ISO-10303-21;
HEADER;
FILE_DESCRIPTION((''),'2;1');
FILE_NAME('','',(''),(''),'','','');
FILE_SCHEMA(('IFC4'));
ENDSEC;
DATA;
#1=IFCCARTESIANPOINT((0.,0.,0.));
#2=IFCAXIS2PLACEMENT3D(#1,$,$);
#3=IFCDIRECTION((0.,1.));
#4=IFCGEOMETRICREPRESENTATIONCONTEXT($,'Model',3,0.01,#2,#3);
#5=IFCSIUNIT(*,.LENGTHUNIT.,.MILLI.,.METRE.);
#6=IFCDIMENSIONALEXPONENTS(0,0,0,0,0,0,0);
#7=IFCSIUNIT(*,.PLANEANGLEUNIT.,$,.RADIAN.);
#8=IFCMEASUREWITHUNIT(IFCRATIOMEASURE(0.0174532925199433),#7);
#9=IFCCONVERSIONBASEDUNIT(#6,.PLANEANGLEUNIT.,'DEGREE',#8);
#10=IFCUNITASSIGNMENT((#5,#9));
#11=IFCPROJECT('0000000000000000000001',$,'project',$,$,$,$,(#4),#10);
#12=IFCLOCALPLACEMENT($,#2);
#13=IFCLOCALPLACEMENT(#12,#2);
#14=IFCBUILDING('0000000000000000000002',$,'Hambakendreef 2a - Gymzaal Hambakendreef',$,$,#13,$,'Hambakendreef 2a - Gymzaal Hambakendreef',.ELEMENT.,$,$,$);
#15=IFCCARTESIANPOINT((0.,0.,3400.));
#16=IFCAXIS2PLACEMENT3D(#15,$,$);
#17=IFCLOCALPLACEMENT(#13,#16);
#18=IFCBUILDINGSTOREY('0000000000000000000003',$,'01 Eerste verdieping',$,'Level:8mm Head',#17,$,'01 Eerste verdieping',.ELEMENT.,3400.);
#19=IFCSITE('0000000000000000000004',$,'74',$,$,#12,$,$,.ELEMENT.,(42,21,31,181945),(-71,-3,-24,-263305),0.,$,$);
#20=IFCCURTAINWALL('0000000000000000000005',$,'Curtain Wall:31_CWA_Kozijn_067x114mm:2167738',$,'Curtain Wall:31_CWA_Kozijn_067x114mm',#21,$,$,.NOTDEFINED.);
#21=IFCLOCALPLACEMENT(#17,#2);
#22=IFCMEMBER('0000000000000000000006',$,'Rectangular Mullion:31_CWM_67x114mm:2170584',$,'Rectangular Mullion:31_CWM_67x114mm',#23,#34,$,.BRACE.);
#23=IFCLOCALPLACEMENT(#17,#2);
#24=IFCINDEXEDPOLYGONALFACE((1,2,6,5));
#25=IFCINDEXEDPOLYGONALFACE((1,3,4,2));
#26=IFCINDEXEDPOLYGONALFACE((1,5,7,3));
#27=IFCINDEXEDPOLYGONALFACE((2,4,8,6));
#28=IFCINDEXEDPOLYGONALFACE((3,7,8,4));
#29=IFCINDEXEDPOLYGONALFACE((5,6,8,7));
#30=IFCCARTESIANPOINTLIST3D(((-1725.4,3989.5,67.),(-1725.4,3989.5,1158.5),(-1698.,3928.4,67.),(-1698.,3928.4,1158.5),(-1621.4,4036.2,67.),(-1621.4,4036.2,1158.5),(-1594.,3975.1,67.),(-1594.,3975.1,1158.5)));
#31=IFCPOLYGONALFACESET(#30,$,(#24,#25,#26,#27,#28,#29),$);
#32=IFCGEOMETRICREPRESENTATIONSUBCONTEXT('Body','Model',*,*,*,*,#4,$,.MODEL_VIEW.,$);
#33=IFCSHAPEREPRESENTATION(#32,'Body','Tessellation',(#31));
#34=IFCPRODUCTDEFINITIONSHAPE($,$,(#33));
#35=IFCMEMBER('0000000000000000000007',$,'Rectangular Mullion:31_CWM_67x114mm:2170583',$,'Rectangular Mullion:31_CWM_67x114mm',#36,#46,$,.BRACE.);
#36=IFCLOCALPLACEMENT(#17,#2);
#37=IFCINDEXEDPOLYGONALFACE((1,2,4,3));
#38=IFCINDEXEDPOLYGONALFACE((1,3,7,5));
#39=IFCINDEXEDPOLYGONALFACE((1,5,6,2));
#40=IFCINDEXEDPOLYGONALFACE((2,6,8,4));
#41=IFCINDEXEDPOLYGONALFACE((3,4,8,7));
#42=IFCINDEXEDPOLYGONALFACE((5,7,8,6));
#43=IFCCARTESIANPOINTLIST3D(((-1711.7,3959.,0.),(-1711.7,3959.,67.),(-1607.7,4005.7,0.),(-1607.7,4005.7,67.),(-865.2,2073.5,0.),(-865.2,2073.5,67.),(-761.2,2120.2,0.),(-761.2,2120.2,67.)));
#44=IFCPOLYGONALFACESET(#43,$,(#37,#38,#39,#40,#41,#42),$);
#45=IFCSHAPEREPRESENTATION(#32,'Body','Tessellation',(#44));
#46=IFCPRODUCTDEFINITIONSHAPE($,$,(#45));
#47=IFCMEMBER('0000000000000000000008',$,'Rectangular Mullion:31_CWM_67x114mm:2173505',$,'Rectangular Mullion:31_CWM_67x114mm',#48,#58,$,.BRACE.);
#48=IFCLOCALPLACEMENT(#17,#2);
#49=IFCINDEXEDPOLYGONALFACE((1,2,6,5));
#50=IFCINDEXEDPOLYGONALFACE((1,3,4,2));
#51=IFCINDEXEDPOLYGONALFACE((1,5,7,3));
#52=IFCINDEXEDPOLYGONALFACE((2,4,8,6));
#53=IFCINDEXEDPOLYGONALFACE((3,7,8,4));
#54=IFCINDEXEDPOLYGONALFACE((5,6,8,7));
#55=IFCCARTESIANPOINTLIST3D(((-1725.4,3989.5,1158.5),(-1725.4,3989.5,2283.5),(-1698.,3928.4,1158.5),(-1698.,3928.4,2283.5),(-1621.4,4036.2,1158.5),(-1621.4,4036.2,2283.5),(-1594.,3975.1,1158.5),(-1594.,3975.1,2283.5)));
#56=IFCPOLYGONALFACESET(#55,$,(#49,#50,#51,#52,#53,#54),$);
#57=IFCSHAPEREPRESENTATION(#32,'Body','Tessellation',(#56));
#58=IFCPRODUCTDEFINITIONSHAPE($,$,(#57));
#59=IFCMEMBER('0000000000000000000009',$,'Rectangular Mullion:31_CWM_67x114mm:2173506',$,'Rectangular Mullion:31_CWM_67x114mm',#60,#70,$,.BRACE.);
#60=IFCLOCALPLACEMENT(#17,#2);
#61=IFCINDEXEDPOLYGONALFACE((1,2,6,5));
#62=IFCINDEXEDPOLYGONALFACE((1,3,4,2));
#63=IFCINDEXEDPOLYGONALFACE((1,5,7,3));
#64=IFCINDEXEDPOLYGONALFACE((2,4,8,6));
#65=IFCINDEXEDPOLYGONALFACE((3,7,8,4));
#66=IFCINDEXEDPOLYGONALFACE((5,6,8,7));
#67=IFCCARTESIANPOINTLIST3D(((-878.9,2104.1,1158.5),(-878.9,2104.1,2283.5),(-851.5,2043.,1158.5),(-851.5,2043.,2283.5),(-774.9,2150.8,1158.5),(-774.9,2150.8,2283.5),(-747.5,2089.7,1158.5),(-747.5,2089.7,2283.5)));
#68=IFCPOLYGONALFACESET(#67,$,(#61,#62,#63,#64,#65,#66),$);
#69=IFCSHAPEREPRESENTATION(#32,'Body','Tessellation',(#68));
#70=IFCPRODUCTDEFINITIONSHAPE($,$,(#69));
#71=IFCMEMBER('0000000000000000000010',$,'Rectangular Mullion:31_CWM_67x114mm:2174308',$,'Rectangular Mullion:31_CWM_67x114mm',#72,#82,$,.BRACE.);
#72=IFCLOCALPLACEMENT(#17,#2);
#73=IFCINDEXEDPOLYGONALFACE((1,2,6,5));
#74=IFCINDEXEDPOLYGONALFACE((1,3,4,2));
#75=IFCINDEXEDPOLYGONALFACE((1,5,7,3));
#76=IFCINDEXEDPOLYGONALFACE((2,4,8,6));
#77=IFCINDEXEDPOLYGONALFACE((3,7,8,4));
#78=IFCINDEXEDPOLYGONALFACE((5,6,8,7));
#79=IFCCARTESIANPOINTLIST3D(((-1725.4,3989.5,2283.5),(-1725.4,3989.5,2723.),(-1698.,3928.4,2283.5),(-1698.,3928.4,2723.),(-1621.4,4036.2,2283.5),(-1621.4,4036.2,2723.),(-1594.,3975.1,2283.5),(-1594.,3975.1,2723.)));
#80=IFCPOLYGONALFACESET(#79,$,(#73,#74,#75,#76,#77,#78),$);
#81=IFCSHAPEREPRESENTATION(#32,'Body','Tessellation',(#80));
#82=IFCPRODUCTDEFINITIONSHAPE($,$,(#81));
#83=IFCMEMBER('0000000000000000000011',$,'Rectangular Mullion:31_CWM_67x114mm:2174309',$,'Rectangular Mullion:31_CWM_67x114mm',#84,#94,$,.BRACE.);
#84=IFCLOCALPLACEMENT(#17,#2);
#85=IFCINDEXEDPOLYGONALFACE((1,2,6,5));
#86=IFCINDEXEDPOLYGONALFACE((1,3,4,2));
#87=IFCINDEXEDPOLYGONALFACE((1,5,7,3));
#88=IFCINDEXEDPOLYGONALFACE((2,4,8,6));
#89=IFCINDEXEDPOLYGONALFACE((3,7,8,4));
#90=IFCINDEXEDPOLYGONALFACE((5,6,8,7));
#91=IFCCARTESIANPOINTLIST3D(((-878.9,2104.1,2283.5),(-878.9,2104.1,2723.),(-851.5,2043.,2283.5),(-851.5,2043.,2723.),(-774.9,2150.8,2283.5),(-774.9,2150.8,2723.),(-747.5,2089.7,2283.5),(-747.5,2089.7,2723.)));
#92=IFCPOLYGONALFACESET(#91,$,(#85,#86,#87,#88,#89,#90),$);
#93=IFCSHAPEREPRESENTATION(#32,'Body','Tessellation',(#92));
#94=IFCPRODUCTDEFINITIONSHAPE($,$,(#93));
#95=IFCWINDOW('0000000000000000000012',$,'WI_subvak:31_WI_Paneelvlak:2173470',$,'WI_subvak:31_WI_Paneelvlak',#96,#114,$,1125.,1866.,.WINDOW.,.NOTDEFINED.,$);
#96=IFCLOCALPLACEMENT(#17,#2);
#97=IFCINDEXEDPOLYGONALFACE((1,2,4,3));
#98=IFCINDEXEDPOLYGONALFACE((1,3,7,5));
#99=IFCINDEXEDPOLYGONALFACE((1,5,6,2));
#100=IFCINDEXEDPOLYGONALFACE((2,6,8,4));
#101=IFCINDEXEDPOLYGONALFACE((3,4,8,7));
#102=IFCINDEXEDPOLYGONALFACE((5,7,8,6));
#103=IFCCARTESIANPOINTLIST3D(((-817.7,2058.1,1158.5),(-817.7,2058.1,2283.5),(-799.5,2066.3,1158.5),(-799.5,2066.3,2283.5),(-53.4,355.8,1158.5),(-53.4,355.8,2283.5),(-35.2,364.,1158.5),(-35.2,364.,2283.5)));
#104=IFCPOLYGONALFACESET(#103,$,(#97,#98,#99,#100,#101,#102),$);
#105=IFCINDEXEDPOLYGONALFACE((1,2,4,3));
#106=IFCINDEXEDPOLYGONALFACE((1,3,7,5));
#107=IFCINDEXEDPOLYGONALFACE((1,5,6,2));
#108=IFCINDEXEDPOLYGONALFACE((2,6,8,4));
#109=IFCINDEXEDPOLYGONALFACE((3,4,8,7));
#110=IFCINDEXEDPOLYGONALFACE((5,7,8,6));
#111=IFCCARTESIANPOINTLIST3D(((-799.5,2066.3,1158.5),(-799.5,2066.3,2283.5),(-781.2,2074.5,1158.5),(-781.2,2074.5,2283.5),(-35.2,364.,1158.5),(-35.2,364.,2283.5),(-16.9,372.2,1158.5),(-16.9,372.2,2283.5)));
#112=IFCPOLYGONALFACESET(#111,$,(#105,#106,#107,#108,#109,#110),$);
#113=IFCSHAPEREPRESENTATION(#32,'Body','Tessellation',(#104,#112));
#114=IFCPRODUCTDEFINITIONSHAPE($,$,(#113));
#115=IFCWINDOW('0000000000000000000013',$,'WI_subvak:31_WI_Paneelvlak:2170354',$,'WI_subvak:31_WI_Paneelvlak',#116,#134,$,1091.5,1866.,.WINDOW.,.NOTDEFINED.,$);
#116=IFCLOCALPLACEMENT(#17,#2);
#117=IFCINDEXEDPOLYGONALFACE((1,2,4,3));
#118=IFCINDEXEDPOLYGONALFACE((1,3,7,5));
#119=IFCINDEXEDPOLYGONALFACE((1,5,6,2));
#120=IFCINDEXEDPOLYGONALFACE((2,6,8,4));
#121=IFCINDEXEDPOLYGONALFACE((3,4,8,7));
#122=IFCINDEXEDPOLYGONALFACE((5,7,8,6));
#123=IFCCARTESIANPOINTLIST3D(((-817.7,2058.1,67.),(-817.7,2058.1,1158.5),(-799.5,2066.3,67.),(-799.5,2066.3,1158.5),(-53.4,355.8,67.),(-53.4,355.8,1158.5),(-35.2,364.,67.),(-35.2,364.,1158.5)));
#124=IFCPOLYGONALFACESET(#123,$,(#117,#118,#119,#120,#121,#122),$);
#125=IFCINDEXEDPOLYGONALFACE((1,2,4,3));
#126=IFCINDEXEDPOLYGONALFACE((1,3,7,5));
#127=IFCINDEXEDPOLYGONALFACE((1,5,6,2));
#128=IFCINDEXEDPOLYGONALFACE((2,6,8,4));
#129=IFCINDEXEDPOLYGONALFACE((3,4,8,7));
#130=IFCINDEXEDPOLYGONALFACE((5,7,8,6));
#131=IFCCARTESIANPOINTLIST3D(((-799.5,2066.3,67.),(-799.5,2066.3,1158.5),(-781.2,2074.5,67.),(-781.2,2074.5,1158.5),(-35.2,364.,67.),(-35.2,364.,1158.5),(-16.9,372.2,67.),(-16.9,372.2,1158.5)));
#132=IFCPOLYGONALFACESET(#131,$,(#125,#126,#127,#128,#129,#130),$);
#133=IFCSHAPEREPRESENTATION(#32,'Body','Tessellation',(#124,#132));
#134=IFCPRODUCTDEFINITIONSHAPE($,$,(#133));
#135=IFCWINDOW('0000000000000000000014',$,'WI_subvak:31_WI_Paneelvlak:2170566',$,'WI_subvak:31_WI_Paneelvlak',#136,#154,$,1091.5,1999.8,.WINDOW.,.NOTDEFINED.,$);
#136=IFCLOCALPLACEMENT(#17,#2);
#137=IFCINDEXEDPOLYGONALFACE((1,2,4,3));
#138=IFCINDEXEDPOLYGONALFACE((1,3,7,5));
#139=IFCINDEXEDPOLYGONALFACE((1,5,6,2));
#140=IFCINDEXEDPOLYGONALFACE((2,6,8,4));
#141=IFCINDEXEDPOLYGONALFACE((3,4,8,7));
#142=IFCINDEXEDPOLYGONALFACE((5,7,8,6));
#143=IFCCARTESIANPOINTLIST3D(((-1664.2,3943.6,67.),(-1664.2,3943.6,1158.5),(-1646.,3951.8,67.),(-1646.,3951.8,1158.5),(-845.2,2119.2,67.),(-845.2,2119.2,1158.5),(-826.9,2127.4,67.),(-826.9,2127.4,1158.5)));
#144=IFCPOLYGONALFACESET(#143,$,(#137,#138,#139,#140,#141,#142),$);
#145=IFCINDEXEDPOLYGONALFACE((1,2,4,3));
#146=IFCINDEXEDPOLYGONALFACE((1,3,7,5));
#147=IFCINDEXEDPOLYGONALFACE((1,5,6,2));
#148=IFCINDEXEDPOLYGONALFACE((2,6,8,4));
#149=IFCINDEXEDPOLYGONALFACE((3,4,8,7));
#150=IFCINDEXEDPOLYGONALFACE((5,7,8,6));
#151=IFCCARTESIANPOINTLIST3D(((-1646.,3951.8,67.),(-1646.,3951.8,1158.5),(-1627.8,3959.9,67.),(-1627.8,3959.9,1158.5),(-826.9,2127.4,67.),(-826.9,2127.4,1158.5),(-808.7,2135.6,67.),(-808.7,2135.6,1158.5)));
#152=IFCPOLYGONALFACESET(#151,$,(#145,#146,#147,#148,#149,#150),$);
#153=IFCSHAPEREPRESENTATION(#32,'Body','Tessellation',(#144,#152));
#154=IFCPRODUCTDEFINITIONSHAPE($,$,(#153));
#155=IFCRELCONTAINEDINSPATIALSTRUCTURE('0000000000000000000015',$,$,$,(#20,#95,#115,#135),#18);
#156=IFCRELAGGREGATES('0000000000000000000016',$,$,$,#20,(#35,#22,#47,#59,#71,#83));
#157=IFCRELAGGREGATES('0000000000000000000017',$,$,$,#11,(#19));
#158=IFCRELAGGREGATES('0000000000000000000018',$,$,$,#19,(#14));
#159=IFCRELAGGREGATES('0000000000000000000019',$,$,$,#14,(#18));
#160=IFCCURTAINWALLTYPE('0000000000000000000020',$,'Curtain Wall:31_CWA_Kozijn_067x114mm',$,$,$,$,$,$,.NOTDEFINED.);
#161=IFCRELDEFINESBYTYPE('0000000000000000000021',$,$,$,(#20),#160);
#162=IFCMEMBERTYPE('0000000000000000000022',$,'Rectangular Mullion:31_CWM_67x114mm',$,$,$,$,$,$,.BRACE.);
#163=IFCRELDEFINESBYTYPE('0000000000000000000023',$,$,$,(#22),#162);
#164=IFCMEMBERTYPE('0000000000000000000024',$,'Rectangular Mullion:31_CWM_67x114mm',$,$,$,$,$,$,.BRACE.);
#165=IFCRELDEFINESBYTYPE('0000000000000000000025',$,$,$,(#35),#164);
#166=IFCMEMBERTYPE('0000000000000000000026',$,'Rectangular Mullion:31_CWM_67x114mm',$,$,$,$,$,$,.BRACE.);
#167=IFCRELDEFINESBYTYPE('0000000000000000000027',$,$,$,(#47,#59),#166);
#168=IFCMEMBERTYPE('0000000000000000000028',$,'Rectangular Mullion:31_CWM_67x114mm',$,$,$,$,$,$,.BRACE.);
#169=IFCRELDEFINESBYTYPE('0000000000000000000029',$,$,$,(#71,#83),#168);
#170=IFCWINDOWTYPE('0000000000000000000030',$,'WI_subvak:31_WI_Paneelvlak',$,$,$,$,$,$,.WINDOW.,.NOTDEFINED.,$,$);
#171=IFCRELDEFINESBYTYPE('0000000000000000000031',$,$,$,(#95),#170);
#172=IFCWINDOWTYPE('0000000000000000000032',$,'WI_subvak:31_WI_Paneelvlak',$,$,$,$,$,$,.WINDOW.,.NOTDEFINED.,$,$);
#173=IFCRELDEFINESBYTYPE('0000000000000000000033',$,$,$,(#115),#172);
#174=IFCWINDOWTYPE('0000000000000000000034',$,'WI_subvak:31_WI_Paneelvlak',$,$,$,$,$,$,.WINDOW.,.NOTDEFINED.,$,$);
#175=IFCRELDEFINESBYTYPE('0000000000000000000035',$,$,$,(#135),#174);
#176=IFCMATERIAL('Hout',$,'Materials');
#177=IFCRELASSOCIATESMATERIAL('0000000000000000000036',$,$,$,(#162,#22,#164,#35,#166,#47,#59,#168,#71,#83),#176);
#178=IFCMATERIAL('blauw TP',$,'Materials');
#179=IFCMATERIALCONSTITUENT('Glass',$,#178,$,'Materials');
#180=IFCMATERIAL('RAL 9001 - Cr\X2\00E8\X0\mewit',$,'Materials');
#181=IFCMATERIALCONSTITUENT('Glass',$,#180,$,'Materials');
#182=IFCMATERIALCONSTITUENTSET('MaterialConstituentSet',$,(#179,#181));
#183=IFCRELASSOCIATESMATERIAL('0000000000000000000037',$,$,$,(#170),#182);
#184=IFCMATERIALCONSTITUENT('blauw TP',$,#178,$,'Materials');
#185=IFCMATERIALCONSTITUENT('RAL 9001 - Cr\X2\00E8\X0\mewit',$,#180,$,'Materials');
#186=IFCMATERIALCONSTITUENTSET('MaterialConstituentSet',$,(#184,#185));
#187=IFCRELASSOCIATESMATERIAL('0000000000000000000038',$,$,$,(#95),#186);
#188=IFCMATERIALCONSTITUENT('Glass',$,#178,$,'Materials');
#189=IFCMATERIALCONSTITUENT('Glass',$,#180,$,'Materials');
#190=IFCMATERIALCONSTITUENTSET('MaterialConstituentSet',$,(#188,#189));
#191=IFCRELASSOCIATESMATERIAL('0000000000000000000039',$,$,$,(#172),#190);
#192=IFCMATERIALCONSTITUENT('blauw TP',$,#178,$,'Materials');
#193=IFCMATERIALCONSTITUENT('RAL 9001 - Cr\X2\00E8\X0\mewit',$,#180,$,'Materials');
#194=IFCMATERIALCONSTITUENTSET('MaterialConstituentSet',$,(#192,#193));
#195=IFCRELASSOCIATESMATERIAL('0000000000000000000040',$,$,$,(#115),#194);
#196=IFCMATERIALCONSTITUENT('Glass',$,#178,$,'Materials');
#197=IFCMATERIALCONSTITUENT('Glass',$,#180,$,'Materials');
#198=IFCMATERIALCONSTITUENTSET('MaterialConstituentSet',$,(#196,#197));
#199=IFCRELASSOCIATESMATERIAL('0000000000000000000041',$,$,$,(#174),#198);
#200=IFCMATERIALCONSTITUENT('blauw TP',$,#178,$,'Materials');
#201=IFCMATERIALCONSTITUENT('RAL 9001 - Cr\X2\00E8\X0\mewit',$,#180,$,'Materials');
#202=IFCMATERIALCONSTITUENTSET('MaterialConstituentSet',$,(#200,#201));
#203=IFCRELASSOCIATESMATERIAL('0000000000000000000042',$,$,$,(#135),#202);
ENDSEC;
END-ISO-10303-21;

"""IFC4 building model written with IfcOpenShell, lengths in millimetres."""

from ifc_helpers import new_model, entity, si_unit, converted_unit, direction, frame, origin, place, context, subcontext, project, spatial, indexed_curve, outline, extrude, source, transform, mapped, material, constituent, constituent_set, type_object, type_shapes, element, aggregate, save


model = new_model("IFC4")

# Units and contexts
model_context = context("Model", 3, precision=0.01, world=origin(), true_north=direction((0.0, 1.0)))
body_context = subcontext(model_context, "Body", "Model", "MODEL_VIEW")
ifc_project = project(units=[si_unit("LENGTHUNIT", "METRE", prefix="MILLI"), converted_unit("PLANEANGLEUNIT", "DEGREE", entity("IfcRatioMeasure", 0.0174532925199433), si_unit("PLANEANGLEUNIT", "RADIAN"), dimensions=[0, 0, 0, 0, 0, 0, 0])], contexts=[model_context])

# Site, building, storey
site_placement = place(None, origin())
site = spatial("IfcSite", under=ifc_project, at=site_placement, Name="74", CompositionType="ELEMENT", RefLatitude=(42, 21, 31, 181945), RefLongitude=(-71, -3, -24, -263305), RefElevation=0.0)
building_placement = place(site_placement, origin())
building = spatial("IfcBuilding", under=site, at=building_placement, Name="Hambakendreef 2a - Gymzaal Hambakendreef", LongName="Hambakendreef 2a - Gymzaal Hambakendreef", CompositionType="ELEMENT")
storey_placement = place(building_placement, frame((0.0, 0.0, 3400.0)))
storey = spatial("IfcBuildingStorey", under=building, at=storey_placement, Name="01 Eerste verdieping", ObjectType="Level:8mm Head", LongName="01 Eerste verdieping", CompositionType="ELEMENT", Elevation=3400.0)

# Curtain wall, members
curtain_wall_type = type_object("IfcCurtainWallType", Name="Curtain Wall:31_CWA_Kozijn_067x114mm", PredefinedType="NOTDEFINED")
curtain_wall_placement = place(storey_placement, frame((0.0, 0.0, -3400.0)))
curtain_wall = element("IfcCurtainWall", 1, at=curtain_wall_placement, inside=storey, type_object=curtain_wall_type, Name="Curtain Wall:31_CWA_Kozijn_067x114mm:2167738", ObjectType="Curtain Wall:31_CWA_Kozijn_067x114mm", PredefinedType="NOTDEFINED")
ifc_material_1 = material(Name="Hout", Category="Materials")
member_type_1 = type_object("IfcMemberType", Name="Rectangular Mullion:31_CWM_67x114mm", PredefinedType="BRACE", material=ifc_material_1)
shared_shape_1 = source(origin(), body_context, "Body", "SweptSolid", [
    extrude(outline(indexed_curve([(-57.0, -33.5), (57.0, -33.5), (57.0, 33.5), (-57.0, 33.5), (-57.0, -33.5)], self_intersect=False)), frame((0.0, 0.0, -1091.5), z_axis=(0.0, 0.0, 1.0), x_axis=(0.0, -1.0, 0.0)), (0.0, 0.0, 1.0), 1091.5),
])
type_shapes(member_type_1, [shared_shape_1])
member_1_placement = place(storey_placement, frame((-1659.7, 3982.3, 67.0), z_axis=(0.0, 0.0, -1.0), x_axis=(0.40959, -0.91227, 0.0)))
member_1 = element("IfcMember", 2, at=member_1_placement, type_object=member_type_1, material=ifc_material_1, Name="Rectangular Mullion:31_CWM_67x114mm:2170584", ObjectType="Rectangular Mullion:31_CWM_67x114mm", PredefinedType="BRACE", context=body_context, shape_type="MappedRepresentation", body=[
    mapped(shared_shape_1, transform((0.0, 0.0, 0.0), scale=1.0)),
])
member_type_2 = type_object("IfcMemberType", Name="Rectangular Mullion:31_CWM_67x114mm", PredefinedType="BRACE", material=ifc_material_1)
shared_shape_2 = source(origin(), body_context, "Body", "SweptSolid", [
    extrude(outline(indexed_curve([(-57.0, -33.5), (57.0, -33.5), (57.0, 33.5), (-57.0, 33.5), (-57.0, -33.5)], self_intersect=False)), frame((-33.5, 0.0, -2066.8), z_axis=(0.0, 0.0, 1.0), x_axis=(0.0, -1.0, 0.0)), (0.0, 0.0, 1.0), 2066.8),
])
type_shapes(member_type_2, [shared_shape_2])
member_2_placement = place(storey_placement, frame((-1659.7, 3982.3, 0.0), z_axis=(-0.40959, 0.91227, 0.0), x_axis=(0.0, 0.0, -1.0)))
member_2 = element("IfcMember", 3, at=member_2_placement, type_object=member_type_2, material=ifc_material_1, Name="Rectangular Mullion:31_CWM_67x114mm:2170583", ObjectType="Rectangular Mullion:31_CWM_67x114mm", PredefinedType="BRACE", context=body_context, shape_type="MappedRepresentation", body=[
    mapped(shared_shape_2, transform((0.0, 0.0, 0.0), scale=1.0)),
])
member_type_3 = type_object("IfcMemberType", Name="Rectangular Mullion:31_CWM_67x114mm", PredefinedType="BRACE", material=ifc_material_1)
shared_shape_3 = source(origin(), body_context, "Body", "SweptSolid", [
    extrude(outline(indexed_curve([(-57.0, -33.5), (57.0, -33.5), (57.0, 33.5), (-57.0, 33.5), (-57.0, -33.5)], self_intersect=False)), frame((0.0, 0.0, -1125.0), z_axis=(0.0, 0.0, 1.0), x_axis=(0.0, -1.0, 0.0)), (0.0, 0.0, 1.0), 1125.0),
])
type_shapes(member_type_3, [shared_shape_3])
member_3_placement = place(storey_placement, frame((-1659.7, 3982.3, 1158.5), z_axis=(0.0, 0.0, -1.0), x_axis=(0.40959, -0.91227, 0.0)))
member_3 = element("IfcMember", 4, at=member_3_placement, type_object=member_type_3, material=ifc_material_1, Name="Rectangular Mullion:31_CWM_67x114mm:2173505", ObjectType="Rectangular Mullion:31_CWM_67x114mm", PredefinedType="BRACE", context=body_context, shape_type="MappedRepresentation", body=[
    mapped(shared_shape_3, transform((0.0, 0.0, 0.0), scale=1.0)),
])
member_4_placement = place(storey_placement, frame((-813.2, 2096.9, 1158.5), z_axis=(0.0, 0.0, -1.0), x_axis=(0.40959, -0.91227, 0.0)))
member_4 = element("IfcMember", 5, at=member_4_placement, type_object=member_type_3, material=ifc_material_1, Name="Rectangular Mullion:31_CWM_67x114mm:2173506", ObjectType="Rectangular Mullion:31_CWM_67x114mm", PredefinedType="BRACE", context=body_context, shape_type="MappedRepresentation", body=[
    mapped(shared_shape_3, transform((0.0, 0.0, 0.0), scale=1.0)),
])
member_type_4 = type_object("IfcMemberType", Name="Rectangular Mullion:31_CWM_67x114mm", PredefinedType="BRACE", material=ifc_material_1)
shared_shape_4 = source(origin(), body_context, "Body", "SweptSolid", [
    extrude(outline(indexed_curve([(-57.0, -33.5), (57.0, -33.5), (57.0, 33.5), (-57.0, 33.5), (-57.0, -33.5)], self_intersect=False)), frame((0.0, 0.0, -439.5), z_axis=(0.0, 0.0, 1.0), x_axis=(0.0, -1.0, 0.0)), (0.0, 0.0, 1.0), 439.5),
])
type_shapes(member_type_4, [shared_shape_4])
member_5_placement = place(storey_placement, frame((-1659.7, 3982.3, 2283.5), z_axis=(0.0, 0.0, -1.0), x_axis=(0.40959, -0.91227, 0.0)))
member_5 = element("IfcMember", 6, at=member_5_placement, type_object=member_type_4, material=ifc_material_1, Name="Rectangular Mullion:31_CWM_67x114mm:2174308", ObjectType="Rectangular Mullion:31_CWM_67x114mm", PredefinedType="BRACE", context=body_context, shape_type="MappedRepresentation", body=[
    mapped(shared_shape_4, transform((0.0, 0.0, 0.0), scale=1.0)),
])
member_6_placement = place(storey_placement, frame((-813.2, 2096.9, 2283.5), z_axis=(0.0, 0.0, -1.0), x_axis=(0.40959, -0.91227, 0.0)))
member_6 = element("IfcMember", 7, at=member_6_placement, type_object=member_type_4, material=ifc_material_1, Name="Rectangular Mullion:31_CWM_67x114mm:2174309", ObjectType="Rectangular Mullion:31_CWM_67x114mm", PredefinedType="BRACE", context=body_context, shape_type="MappedRepresentation", body=[
    mapped(shared_shape_4, transform((0.0, 0.0, 0.0), scale=1.0)),
])
aggregate(curtain_wall, [member_2, member_1, member_3, member_4, member_5, member_6])

# Windows
ifc_material_2 = material(Name="blauw TP", Category="Materials")
ifc_constituent_1 = constituent(ifc_material_2, Name="blauw TP", Category="Materials")
ifc_material_3 = material(Name="RAL 9001 - Crèmewit", Category="Materials")
ifc_constituent_2 = constituent(ifc_material_3, Name="RAL 9001 - Crèmewit", Category="Materials")
ifc_constituent_set_1 = constituent_set(constituents=[ifc_constituent_1, ifc_constituent_2], Name="MaterialConstituentSet")
ifc_constituent_3 = constituent(ifc_material_2, Name="Glass", Category="Materials")
ifc_constituent_4 = constituent(ifc_material_3, Name="Glass", Category="Materials")
ifc_constituent_set_2 = constituent_set(constituents=[ifc_constituent_3, ifc_constituent_4], Name="MaterialConstituentSet")
window_type_1 = type_object("IfcWindowType", Name="WI_subvak:31_WI_Paneelvlak", PartitioningType="NOTDEFINED", PredefinedType="WINDOW", material=ifc_constituent_set_2)
shared_shape_5 = source(origin(), body_context, "Body", "SweptSolid", [
    extrude(outline(indexed_curve([(-933.0, -10.0), (933.0, -10.0), (933.0, 10.0), (-933.0, 10.0), (-933.0, -10.0)], self_intersect=False)), frame((0.0, -10.0, 0.0)), (0.0, 0.0, 1.0), 1125.0),
    extrude(outline(indexed_curve([(-933.0, -10.0), (933.0, -10.0), (933.0, 10.0), (-933.0, 10.0), (-933.0, -10.0)], self_intersect=False)), frame((0.0, 10.0, 0.0)), (0.0, 0.0, 1.0), 1125.0),
])
type_shapes(window_type_1, [shared_shape_5])
window_1_placement = place(storey_placement, frame((-417.3, 1215.2, 1158.5), z_axis=(0.0, 0.0, 1.0), x_axis=(0.40959, -0.91227, 0.0)))
element("IfcWindow", 8, at=window_1_placement, inside=storey, type_object=window_type_1, material=ifc_constituent_set_1, Name="WI_subvak:31_WI_Paneelvlak:2173470", ObjectType="WI_subvak:31_WI_Paneelvlak", OverallHeight=1125.0, OverallWidth=1866.0, PartitioningType="NOTDEFINED", PredefinedType="WINDOW", context=body_context, shape_type="MappedRepresentation", body=[
    mapped(shared_shape_5, transform((0.0, 0.0, 0.0), scale=1.0)),
])
ifc_constituent_5 = constituent(ifc_material_2, Name="blauw TP", Category="Materials")
ifc_constituent_6 = constituent(ifc_material_3, Name="RAL 9001 - Crèmewit", Category="Materials")
ifc_constituent_set_3 = constituent_set(constituents=[ifc_constituent_5, ifc_constituent_6], Name="MaterialConstituentSet")
ifc_constituent_7 = constituent(ifc_material_2, Name="Glass", Category="Materials")
ifc_constituent_8 = constituent(ifc_material_3, Name="Glass", Category="Materials")
ifc_constituent_set_4 = constituent_set(constituents=[ifc_constituent_7, ifc_constituent_8], Name="MaterialConstituentSet")
window_type_2 = type_object("IfcWindowType", Name="WI_subvak:31_WI_Paneelvlak", PartitioningType="NOTDEFINED", PredefinedType="WINDOW", material=ifc_constituent_set_4)
shared_shape_6 = source(origin(), body_context, "Body", "SweptSolid", [
    extrude(outline(indexed_curve([(-933.0, -10.0), (933.0, -10.0), (933.0, 10.0), (-933.0, 10.0), (-933.0, -10.0)], self_intersect=False)), frame((0.0, -10.0, 0.0)), (0.0, 0.0, 1.0), 1091.5),
    extrude(outline(indexed_curve([(-933.0, -10.0), (933.0, -10.0), (933.0, 10.0), (-933.0, 10.0), (-933.0, -10.0)], self_intersect=False)), frame((0.0, 10.0, 0.0)), (0.0, 0.0, 1.0), 1091.5),
])
type_shapes(window_type_2, [shared_shape_6])
window_2_placement = place(storey_placement, frame((-417.3, 1215.2, 67.0), z_axis=(0.0, 0.0, 1.0), x_axis=(0.40959, -0.91227, 0.0)))
element("IfcWindow", 9, at=window_2_placement, inside=storey, type_object=window_type_2, material=ifc_constituent_set_3, Name="WI_subvak:31_WI_Paneelvlak:2170354", ObjectType="WI_subvak:31_WI_Paneelvlak", OverallHeight=1091.5, OverallWidth=1866.0, PartitioningType="NOTDEFINED", PredefinedType="WINDOW", context=body_context, shape_type="MappedRepresentation", body=[
    mapped(shared_shape_6, transform((0.0, 0.0, 0.0), scale=1.0)),
])
ifc_constituent_9 = constituent(ifc_material_2, Name="blauw TP", Category="Materials")
ifc_constituent_10 = constituent(ifc_material_3, Name="RAL 9001 - Crèmewit", Category="Materials")
ifc_constituent_set_5 = constituent_set(constituents=[ifc_constituent_9, ifc_constituent_10], Name="MaterialConstituentSet")
ifc_constituent_11 = constituent(ifc_material_2, Name="Glass", Category="Materials")
ifc_constituent_12 = constituent(ifc_material_3, Name="Glass", Category="Materials")
ifc_constituent_set_6 = constituent_set(constituents=[ifc_constituent_11, ifc_constituent_12], Name="MaterialConstituentSet")
window_type_3 = type_object("IfcWindowType", Name="WI_subvak:31_WI_Paneelvlak", PartitioningType="NOTDEFINED", PredefinedType="WINDOW", material=ifc_constituent_set_6)
shared_shape_7 = source(origin(), body_context, "Body", "SweptSolid", [
    extrude(outline(indexed_curve([(-999.9, -10.0), (999.9, -10.0), (999.9, 10.0), (-999.9, 10.0), (-999.9, -10.0)], self_intersect=False)), frame((0.0, -10.0, 0.0)), (0.0, 0.0, 1.0), 1091.5),
    extrude(outline(indexed_curve([(-999.9, -10.0), (999.9, -10.0), (999.9, 10.0), (-999.9, 10.0), (-999.9, -10.0)], self_intersect=False)), frame((0.0, 10.0, 0.0)), (0.0, 0.0, 1.0), 1091.5),
])
type_shapes(window_type_3, [shared_shape_7])
window_3_placement = place(storey_placement, frame((-1236.5, 3039.6, 67.0), z_axis=(0.0, 0.0, 1.0), x_axis=(0.40959, -0.91227, 0.0)))
element("IfcWindow", 10, at=window_3_placement, inside=storey, type_object=window_type_3, material=ifc_constituent_set_5, Name="WI_subvak:31_WI_Paneelvlak:2170566", ObjectType="WI_subvak:31_WI_Paneelvlak", OverallHeight=1091.5, OverallWidth=1999.8, PartitioningType="NOTDEFINED", PredefinedType="WINDOW", context=body_context, shape_type="MappedRepresentation", body=[
    mapped(shared_shape_7, transform((0.0, 0.0, 0.0), scale=1.0)),
])

save(model, "model.ifc")
